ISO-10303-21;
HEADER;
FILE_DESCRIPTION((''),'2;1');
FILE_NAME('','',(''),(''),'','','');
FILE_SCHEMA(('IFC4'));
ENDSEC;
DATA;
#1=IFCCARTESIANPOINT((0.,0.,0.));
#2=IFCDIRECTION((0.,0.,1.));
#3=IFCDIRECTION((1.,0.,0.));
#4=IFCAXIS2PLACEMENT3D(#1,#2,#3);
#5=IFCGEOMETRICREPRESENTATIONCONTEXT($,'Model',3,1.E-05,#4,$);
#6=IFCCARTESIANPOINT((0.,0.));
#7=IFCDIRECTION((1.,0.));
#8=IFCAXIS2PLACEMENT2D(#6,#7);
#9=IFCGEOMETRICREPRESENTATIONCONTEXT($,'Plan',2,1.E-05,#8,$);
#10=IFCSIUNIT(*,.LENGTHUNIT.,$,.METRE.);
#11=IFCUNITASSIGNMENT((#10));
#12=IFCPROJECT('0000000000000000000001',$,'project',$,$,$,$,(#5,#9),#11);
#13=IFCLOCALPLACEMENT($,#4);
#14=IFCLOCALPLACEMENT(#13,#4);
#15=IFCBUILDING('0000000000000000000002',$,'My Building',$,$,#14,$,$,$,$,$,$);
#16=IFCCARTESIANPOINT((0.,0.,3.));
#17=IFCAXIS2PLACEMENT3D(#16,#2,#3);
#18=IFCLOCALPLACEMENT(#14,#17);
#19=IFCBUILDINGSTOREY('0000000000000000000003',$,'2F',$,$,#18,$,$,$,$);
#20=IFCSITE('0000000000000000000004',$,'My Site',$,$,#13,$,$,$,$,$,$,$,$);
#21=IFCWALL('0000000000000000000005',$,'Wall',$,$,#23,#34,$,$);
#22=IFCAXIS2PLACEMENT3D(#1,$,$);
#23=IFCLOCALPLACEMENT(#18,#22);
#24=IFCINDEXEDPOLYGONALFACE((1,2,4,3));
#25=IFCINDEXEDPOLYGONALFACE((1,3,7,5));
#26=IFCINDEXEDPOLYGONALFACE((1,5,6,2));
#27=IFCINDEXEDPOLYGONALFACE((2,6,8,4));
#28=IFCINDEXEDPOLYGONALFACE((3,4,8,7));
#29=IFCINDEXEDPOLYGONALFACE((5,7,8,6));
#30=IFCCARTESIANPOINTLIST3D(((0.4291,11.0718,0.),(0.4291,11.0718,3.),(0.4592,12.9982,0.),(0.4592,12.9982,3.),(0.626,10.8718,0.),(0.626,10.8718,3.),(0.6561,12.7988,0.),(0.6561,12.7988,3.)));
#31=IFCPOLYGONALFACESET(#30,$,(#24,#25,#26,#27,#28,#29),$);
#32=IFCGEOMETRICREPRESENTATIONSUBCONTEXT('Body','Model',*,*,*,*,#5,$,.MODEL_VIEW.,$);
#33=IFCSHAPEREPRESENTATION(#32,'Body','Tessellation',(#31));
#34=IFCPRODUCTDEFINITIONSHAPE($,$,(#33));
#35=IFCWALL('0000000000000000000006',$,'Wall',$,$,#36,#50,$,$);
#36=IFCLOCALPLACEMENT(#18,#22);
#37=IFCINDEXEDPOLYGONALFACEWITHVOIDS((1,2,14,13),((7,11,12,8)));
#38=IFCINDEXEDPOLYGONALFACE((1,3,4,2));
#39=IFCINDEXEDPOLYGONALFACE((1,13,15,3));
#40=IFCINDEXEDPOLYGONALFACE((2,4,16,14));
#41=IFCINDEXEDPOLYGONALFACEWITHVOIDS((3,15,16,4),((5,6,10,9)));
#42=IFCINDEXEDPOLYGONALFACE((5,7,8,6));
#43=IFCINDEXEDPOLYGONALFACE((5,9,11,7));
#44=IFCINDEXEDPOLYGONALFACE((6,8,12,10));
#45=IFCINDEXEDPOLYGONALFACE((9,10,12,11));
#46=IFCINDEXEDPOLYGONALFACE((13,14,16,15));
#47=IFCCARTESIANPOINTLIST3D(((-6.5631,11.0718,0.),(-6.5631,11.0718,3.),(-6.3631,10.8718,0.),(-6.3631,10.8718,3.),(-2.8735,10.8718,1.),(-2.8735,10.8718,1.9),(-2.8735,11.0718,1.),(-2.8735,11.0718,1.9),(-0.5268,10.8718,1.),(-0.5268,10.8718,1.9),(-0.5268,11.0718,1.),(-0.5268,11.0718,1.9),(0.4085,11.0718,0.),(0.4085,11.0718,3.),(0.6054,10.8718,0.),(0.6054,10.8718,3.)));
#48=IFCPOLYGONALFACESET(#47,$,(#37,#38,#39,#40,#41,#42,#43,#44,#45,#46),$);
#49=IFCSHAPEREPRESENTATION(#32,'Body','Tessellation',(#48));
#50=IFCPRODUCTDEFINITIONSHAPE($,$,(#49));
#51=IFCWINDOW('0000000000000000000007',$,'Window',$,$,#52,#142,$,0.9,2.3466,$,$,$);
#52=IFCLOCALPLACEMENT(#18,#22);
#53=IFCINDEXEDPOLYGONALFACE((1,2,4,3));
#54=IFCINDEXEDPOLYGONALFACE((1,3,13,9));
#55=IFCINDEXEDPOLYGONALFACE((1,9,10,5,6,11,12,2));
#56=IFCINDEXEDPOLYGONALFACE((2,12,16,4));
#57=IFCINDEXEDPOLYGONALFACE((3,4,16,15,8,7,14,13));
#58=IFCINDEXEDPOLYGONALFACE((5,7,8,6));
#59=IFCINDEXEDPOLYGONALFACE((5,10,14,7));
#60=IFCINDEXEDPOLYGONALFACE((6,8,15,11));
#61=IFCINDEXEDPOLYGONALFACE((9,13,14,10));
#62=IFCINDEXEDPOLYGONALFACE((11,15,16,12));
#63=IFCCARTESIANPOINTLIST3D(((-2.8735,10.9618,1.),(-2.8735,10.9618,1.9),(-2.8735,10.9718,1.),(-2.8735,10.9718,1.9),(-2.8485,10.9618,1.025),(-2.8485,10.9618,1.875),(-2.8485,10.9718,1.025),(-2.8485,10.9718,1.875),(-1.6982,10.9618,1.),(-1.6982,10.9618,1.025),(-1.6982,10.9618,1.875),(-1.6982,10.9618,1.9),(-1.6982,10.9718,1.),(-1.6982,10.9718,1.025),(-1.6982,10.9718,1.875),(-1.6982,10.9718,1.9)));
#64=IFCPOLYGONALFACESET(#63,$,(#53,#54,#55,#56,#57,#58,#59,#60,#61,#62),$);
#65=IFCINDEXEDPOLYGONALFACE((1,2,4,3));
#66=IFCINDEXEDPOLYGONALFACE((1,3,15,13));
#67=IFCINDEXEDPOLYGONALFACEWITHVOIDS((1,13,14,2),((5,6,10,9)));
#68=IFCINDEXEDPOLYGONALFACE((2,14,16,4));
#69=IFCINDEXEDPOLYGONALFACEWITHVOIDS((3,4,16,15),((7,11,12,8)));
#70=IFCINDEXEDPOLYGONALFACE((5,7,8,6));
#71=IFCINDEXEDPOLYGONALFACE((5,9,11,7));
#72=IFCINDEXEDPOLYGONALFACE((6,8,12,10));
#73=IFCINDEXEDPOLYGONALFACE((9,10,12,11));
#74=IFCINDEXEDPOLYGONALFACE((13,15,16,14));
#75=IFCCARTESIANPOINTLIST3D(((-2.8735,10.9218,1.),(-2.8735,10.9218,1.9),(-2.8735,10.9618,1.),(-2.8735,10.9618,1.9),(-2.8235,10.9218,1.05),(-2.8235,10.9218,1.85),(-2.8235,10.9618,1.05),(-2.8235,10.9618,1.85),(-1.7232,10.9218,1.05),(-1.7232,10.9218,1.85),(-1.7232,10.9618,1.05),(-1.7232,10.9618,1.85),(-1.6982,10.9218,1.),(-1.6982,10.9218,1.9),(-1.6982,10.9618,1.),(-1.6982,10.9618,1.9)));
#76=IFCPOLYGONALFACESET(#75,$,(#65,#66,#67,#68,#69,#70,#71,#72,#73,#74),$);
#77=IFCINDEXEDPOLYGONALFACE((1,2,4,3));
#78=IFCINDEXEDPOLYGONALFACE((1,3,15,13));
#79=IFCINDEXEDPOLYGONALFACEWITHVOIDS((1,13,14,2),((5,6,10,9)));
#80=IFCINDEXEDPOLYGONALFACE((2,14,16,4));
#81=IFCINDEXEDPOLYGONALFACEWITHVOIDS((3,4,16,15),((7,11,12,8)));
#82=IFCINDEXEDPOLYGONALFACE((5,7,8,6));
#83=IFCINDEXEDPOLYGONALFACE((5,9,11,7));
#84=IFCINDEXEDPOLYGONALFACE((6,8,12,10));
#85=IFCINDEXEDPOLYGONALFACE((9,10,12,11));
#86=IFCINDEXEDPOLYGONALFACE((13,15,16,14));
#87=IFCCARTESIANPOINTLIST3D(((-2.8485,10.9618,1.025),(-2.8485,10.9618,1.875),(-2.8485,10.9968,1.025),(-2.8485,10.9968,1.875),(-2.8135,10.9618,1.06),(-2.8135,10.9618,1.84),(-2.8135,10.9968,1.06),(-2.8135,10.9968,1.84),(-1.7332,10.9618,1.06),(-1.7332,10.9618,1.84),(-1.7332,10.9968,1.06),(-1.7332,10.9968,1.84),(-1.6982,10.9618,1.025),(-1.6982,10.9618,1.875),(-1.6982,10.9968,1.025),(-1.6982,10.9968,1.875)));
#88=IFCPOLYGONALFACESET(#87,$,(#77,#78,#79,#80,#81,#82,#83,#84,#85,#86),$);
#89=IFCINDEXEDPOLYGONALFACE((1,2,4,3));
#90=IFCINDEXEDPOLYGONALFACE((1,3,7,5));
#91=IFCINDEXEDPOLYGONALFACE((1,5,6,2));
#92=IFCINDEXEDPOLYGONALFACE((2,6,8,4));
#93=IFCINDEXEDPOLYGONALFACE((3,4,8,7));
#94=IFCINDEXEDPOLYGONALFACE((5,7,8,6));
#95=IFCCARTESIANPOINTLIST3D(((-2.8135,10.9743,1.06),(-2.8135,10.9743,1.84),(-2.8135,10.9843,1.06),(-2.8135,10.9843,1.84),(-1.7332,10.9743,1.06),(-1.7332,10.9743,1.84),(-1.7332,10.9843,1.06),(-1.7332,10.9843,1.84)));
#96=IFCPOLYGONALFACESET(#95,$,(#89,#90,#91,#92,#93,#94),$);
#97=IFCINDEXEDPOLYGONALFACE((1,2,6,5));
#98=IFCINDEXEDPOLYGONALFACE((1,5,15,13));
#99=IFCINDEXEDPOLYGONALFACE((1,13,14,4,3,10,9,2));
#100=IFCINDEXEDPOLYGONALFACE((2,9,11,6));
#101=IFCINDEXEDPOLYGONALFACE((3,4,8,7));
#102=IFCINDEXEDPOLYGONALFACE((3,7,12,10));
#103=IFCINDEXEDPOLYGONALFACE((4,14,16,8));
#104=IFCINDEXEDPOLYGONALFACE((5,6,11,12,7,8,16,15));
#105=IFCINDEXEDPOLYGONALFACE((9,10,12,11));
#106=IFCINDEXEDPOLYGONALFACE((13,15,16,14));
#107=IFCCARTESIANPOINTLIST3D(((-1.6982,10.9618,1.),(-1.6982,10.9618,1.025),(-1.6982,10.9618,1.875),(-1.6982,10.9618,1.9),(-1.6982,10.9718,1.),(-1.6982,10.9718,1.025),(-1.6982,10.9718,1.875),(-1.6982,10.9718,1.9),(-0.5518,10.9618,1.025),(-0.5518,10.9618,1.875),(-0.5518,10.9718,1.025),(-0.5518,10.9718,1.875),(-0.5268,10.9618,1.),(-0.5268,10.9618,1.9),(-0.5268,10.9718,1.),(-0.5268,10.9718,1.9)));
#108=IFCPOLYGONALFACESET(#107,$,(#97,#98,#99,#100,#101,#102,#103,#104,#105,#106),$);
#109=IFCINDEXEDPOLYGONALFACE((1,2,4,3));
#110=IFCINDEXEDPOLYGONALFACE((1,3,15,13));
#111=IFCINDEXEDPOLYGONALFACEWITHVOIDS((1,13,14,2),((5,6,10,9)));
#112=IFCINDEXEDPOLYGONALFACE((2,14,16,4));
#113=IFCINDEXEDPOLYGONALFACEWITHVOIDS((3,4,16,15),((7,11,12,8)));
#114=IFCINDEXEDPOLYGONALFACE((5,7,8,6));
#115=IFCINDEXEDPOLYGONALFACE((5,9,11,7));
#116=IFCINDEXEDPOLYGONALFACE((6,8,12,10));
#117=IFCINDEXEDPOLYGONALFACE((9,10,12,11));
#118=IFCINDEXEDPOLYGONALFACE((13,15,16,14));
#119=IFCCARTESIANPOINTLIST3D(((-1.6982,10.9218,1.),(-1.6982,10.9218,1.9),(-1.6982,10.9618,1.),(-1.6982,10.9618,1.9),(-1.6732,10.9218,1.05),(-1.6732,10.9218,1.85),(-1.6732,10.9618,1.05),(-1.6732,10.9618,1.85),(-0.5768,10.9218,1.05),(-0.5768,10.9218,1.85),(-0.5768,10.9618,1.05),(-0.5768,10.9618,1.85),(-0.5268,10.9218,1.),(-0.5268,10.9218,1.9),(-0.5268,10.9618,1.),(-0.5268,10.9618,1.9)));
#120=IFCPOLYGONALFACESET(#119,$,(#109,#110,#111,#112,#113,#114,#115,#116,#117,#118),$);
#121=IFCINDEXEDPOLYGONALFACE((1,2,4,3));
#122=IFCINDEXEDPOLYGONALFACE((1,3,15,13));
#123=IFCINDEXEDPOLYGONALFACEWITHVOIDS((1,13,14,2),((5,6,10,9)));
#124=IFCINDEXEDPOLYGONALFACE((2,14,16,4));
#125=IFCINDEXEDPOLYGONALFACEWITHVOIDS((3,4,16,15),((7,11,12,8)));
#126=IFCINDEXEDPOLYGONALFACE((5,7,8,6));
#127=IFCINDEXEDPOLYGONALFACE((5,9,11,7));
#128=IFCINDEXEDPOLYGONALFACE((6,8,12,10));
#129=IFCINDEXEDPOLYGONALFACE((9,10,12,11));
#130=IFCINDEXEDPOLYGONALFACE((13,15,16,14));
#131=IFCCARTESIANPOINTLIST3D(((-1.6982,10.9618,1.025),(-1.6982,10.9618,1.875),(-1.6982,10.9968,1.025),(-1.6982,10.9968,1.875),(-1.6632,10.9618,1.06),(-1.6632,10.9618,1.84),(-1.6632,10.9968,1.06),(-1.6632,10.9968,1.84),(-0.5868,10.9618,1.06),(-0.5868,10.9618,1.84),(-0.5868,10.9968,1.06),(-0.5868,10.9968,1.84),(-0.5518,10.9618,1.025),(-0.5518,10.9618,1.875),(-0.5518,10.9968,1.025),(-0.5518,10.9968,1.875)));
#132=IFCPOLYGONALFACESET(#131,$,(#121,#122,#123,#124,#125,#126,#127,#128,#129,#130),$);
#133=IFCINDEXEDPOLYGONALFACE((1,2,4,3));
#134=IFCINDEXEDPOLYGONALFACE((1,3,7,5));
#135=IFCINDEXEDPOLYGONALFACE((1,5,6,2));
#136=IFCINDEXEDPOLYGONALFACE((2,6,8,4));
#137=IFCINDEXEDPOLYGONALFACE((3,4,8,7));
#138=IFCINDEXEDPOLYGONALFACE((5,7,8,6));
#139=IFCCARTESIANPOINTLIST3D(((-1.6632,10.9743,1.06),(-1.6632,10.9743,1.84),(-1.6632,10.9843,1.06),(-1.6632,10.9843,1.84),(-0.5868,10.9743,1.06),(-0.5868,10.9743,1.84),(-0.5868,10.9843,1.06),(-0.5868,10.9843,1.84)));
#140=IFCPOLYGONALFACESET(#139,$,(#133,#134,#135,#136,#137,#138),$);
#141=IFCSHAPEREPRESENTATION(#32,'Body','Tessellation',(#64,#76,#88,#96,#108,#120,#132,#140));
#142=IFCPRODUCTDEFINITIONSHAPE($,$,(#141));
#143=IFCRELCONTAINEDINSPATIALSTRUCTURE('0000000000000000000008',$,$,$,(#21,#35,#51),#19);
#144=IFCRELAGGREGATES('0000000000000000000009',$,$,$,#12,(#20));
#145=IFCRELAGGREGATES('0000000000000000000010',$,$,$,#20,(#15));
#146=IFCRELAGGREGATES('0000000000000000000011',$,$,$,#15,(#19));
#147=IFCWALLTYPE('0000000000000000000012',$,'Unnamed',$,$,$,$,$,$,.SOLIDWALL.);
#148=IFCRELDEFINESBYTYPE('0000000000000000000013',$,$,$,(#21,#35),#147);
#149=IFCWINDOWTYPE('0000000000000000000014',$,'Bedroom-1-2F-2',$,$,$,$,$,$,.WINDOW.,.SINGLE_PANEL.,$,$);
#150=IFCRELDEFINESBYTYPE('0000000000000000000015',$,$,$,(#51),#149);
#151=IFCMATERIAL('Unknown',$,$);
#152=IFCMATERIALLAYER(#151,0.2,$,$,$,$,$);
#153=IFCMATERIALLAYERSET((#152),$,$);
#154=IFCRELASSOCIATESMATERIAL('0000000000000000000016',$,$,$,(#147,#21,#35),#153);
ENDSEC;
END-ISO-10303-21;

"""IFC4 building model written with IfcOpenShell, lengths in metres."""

from ifc_helpers import new_model, entity, si_unit, frame, origin_with_axes, origin_2d_with_axis, place, context, subcontext, project, spatial, line, indexed_curve, outline, extrude, shape, source, transform, mapped, material, layer, layer_set, layer_usage, type_object, type_shapes, element, fill, save


model = new_model("IFC4")

# Units and contexts
model_context = context("Model", 3, precision=1e-05, world=origin_with_axes())
plan_context = context("Plan", 2, precision=1e-05, world=origin_2d_with_axis())
body_context_1 = subcontext(model_context, "Body", "Model", "MODEL_VIEW")
body_context_2 = subcontext(plan_context, "Body", "Plan", "PLAN_VIEW")
ifc_project = project(units=[si_unit("LENGTHUNIT", "METRE")], contexts=[model_context, plan_context])

# Site, building, storey
site_placement = place(None, origin_with_axes())
site = spatial("IfcSite", under=ifc_project, at=site_placement, Name="My Site")
building_placement = place(site_placement, origin_with_axes())
building = spatial("IfcBuilding", under=site, at=building_placement, Name="My Building")
storey_placement = place(building_placement, frame((0.0, 0.0, 3.0), z_axis=(0.0, 0.0, 1.0), x_axis=(1.0, 0.0, 0.0)))
storey = spatial("IfcBuildingStorey", under=building, at=storey_placement, Name="2F")

# Shared definitions
ifc_material = material(Name="Unknown")

# Shared definitions
ifc_layer_1 = layer(ifc_material, 0.2)
ifc_layer_set_1 = layer_set([ifc_layer_1])
wall_type = type_object("IfcWallType", Name="Unnamed", PredefinedType="SOLIDWALL", material=ifc_layer_set_1)

# Wall
ifc_layer_usage_1 = layer_usage(ifc_layer_set_1, "AXIS2", "POSITIVE", 0.0)
wall_1_placement = place(storey_placement, frame((0.4592, 12.9982, 0.0), z_axis=(0.0, 0.0, 1.0), x_axis=(-0.015623, -0.999878, 0.0)))
element("IfcWall", 1, at=wall_1_placement, inside=storey, type_object=wall_type, material=ifc_layer_usage_1, Name="Wall", context=body_context_1, shape_type="SweptSolid", body=[
    extrude(outline(indexed_curve([(0.0, 0.0), (0.1962, 0.2), (2.1235, 0.2), (1.9266, 0.0)], segments=[line(1, 2, 3, 4, 1)])), origin_with_axes(), (0.0, 0.0, 1.0), 3.0),
])

# Wall, opening, window
ifc_layer_usage_2 = layer_usage(ifc_layer_set_1, "AXIS2", "POSITIVE", 0.0)
wall_2_placement = place(storey_placement, frame((0.4085, 11.0718, 0.0), z_axis=(0.0, 0.0, 1.0), x_axis=(-1.0, 0.0, 0.0)))
wall_2 = element("IfcWall", 2, at=wall_2_placement, inside=storey, type_object=wall_type, material=ifc_layer_usage_2, Name="Wall", context=body_context_1, shape_type="SweptSolid", body=[
    extrude(outline(indexed_curve([(0.0, 0.0), (-0.1969, 0.2), (6.7716, 0.2), (6.9715, 0.0)], segments=[line(1, 2, 3, 4, 1)])), origin_with_axes(), (0.0, 0.0, 1.0), 3.0),
])
shared_shape_1 = source(origin_with_axes(), body_context_1, "Body", "SweptSolid", [
    extrude(outline(indexed_curve([(0.0, 0.0), (2.3466, 0.0), (2.3466, 0.9), (0.0, 0.9)], segments=[line(1, 2, 3, 4, 1)])), frame((0.0, -0.6, 0.0), z_axis=(0.0, -1.0, 0.0), x_axis=(1.0, 0.0, 0.0)), (0.0, 0.0, -1.0), 1.2),
])
opening_1_placement = place(wall_2_placement, frame((3.2819, 0.2, 1.0), z_axis=(0.0, 0.0, 1.0), x_axis=(-1.0, 0.0, 0.0)))
opening_1 = element("IfcOpeningElement", 3, at=opening_1_placement, cuts=wall_2, PredefinedType="OPENING", context=body_context_1, shape_type="MappedRepresentation", body=[
    mapped(shared_shape_1, transform((0.0, 0.0, 0.0), x_axis=(1.0, 0.0, 0.0), y_axis=(0.0, 1.0, 0.0), z_axis=(0.0, 0.0, 1.0), scale=1.0)),
])
window_type_1 = type_object("IfcWindowType", Name="Bedroom-1-2F-2", PartitioningType="SINGLE_PANEL", PredefinedType="WINDOW")
shared_shape_2 = source(origin_with_axes(), body_context_1, "Body", "SweptSolid", [
    extrude(outline(indexed_curve([(1.1752, 0.0), (0.0, 0.0), (0.0, 0.9), (1.1752, 0.9), (1.1752, 0.875), (0.025, 0.875), (0.025, 0.025), (1.1752, 0.025)], segments=[line(1, 2, 3, 4, 5, 6, 7, 8, 1)])), frame((0.0, 0.09, 0.0), z_axis=(0.0, -1.0, 0.0), x_axis=(1.0, 0.0, 0.0)), (0.0, 0.0, -1.0), 0.01),
    extrude(outline(indexed_curve([(0.0, 0.0), (1.1752, 0.0), (1.1752, 0.9), (0.0, 0.9)], segments=[line(1, 2, 3, 4, 1)]), holes=[indexed_curve([(0.05, 0.05), (1.1502, 0.05), (1.1502, 0.85), (0.05, 0.85)], segments=[line(1, 2, 3, 4, 1)])]), frame((0.0, 0.05, 0.0), z_axis=(0.0, -1.0, 0.0), x_axis=(1.0, 0.0, 0.0)), (0.0, 0.0, -1.0), 0.04),
    extrude(outline(indexed_curve([(0.0, 0.0), (1.1502, 0.0), (1.1502, 0.85), (0.0, 0.85)], segments=[line(1, 2, 3, 4, 1)]), holes=[indexed_curve([(0.035, 0.035), (1.1152, 0.035), (1.1152, 0.815), (0.035, 0.815)], segments=[line(1, 2, 3, 4, 1)])]), frame((0.025, 0.09, 0.025), z_axis=(0.0, -1.0, 0.0), x_axis=(1.0, 0.0, 0.0)), (0.0, 0.0, -1.0), 0.035),
    extrude(outline(indexed_curve([(0.035, 0.035), (1.1152, 0.035), (1.1152, 0.815), (0.035, 0.815)], segments=[line(1, 2, 3, 4, 1)])), frame((0.025, 0.1025, 0.025), z_axis=(0.0, -1.0, 0.0), x_axis=(1.0, 0.0, 0.0)), (0.0, 0.0, -1.0), 0.01),
    extrude(outline(indexed_curve([(0.0, 0.9), (1.1714, 0.9), (1.1714, 0.0), (0.0, 0.0), (0.0, 0.025), (1.1464, 0.025), (1.1464, 0.875), (0.0, 0.875)], segments=[line(1, 2, 3, 4, 5, 6, 7, 8, 1)])), frame((1.1752, 0.09, 0.0), z_axis=(0.0, -1.0, 0.0), x_axis=(1.0, 0.0, 0.0)), (0.0, 0.0, -1.0), 0.01),
    extrude(outline(indexed_curve([(0.0, 0.0), (1.1714, 0.0), (1.1714, 0.9), (0.0, 0.9)], segments=[line(1, 2, 3, 4, 1)]), holes=[indexed_curve([(0.025, 0.05), (1.1214, 0.05), (1.1214, 0.85), (0.025, 0.85)], segments=[line(1, 2, 3, 4, 1)])]), frame((1.1752, 0.05, 0.0), z_axis=(0.0, -1.0, 0.0), x_axis=(1.0, 0.0, 0.0)), (0.0, 0.0, -1.0), 0.04),
    extrude(outline(indexed_curve([(0.0, 0.0), (1.1464, 0.0), (1.1464, 0.85), (0.0, 0.85)], segments=[line(1, 2, 3, 4, 1)]), holes=[indexed_curve([(0.035, 0.035), (1.1114, 0.035), (1.1114, 0.815), (0.035, 0.815)], segments=[line(1, 2, 3, 4, 1)])]), frame((1.1752, 0.09, 0.025), z_axis=(0.0, -1.0, 0.0), x_axis=(1.0, 0.0, 0.0)), (0.0, 0.0, -1.0), 0.035),
    extrude(outline(indexed_curve([(0.035, 0.035), (1.1114, 0.035), (1.1114, 0.815), (0.035, 0.815)], segments=[line(1, 2, 3, 4, 1)])), frame((1.1752, 0.1025, 0.025), z_axis=(0.0, -1.0, 0.0), x_axis=(1.0, 0.0, 0.0)), (0.0, 0.0, -1.0), 0.01),
])
shared_shape_3 = source(origin_with_axes(), body_context_2, "Body", "Curve2D", [
    entity("IfcIndexedPolyCurve", entity("IfcCartesianPointList2D", [[0.05, 0.05], [1.1502, 0.05]])),
    entity("IfcIndexedPolyCurve", entity("IfcCartesianPointList2D", [[0.0, 0.1], [0.025, 0.1], [0.025, 0.09], [0.05, 0.09], [0.05, 0.05], [0.0, 0.05]]), [entity("IfcLineIndex", [1, 2, 3, 4, 5, 6, 1])]),
    entity("IfcIndexedPolyCurve", entity("IfcCartesianPointList2D", [[1.1752, 0.1], [1.1752, 0.1], [1.1752, 0.09], [1.1502, 0.09], [1.1502, 0.05], [1.1752, 0.05]])),
    entity("IfcIndexedPolyCurve", entity("IfcCartesianPointList2D", [[0.025, 0.09], [0.06, 0.09], [0.06, 0.125], [0.025, 0.125]]), [entity("IfcLineIndex", [1, 2, 3, 4, 1])]),
    entity("IfcIndexedPolyCurve", entity("IfcCartesianPointList2D", [[1.1752, 0.09], [1.1402, 0.09], [1.1402, 0.125], [1.1752, 0.125]]), [entity("IfcLineIndex", [1, 2, 3, 4, 1])]),
    entity("IfcIndexedPolyCurve", entity("IfcCartesianPointList2D", [[0.06, 0.09], [1.1402, 0.09]])),
    entity("IfcIndexedPolyCurve", entity("IfcCartesianPointList2D", [[0.06, 0.125], [1.1402, 0.125]])),
    entity("IfcIndexedPolyCurve", entity("IfcCartesianPointList2D", [[0.06, 0.1075], [1.1402, 0.1075]])),
    entity("IfcIndexedPolyCurve", entity("IfcCartesianPointList2D", [[1.2002, 0.05], [2.2966, 0.05]])),
    entity("IfcIndexedPolyCurve", entity("IfcCartesianPointList2D", [[1.1752, 0.1], [1.1752, 0.1], [1.1752, 0.09], [1.2002, 0.09], [1.2002, 0.05], [1.1752, 0.05]])),
    entity("IfcIndexedPolyCurve", entity("IfcCartesianPointList2D", [[2.3466, 0.1], [2.3216, 0.1], [2.3216, 0.09], [2.2966, 0.09], [2.2966, 0.05], [2.3466, 0.05]]), [entity("IfcLineIndex", [1, 2, 3, 4, 5, 6, 1])]),
    entity("IfcIndexedPolyCurve", entity("IfcCartesianPointList2D", [[1.1752, 0.09], [1.2102, 0.09], [1.2102, 0.125], [1.1752, 0.125]]), [entity("IfcLineIndex", [1, 2, 3, 4, 1])]),
    entity("IfcIndexedPolyCurve", entity("IfcCartesianPointList2D", [[2.3216, 0.09], [2.2866, 0.09], [2.2866, 0.125], [2.3216, 0.125]]), [entity("IfcLineIndex", [1, 2, 3, 4, 1])]),
    entity("IfcIndexedPolyCurve", entity("IfcCartesianPointList2D", [[1.2102, 0.09], [2.2866, 0.09]])),
    entity("IfcIndexedPolyCurve", entity("IfcCartesianPointList2D", [[1.2102, 0.125], [2.2866, 0.125]])),
    entity("IfcIndexedPolyCurve", entity("IfcCartesianPointList2D", [[1.2102, 0.1075], [2.2866, 0.1075]])),
])
type_shapes(window_type_1, [shared_shape_2, shared_shape_3])
window_1_placement = place(opening_1_placement, frame((0.0, 0.0, 0.0), z_axis=(0.0, 0.0, 1.0), x_axis=(1.0, 0.0, 0.0)))
window_1 = element("IfcWindow", 4, at=window_1_placement, inside=storey, type_object=window_type_1, Name="Window", OverallHeight=0.9, OverallWidth=2.3466, shapes=[
    shape(body_context_1, "Body", "MappedRepresentation", [mapped(shared_shape_2, transform((0.0, 0.0, 0.0), x_axis=(1.0, 0.0, 0.0), y_axis=(0.0, 1.0, 0.0), z_axis=(0.0, 0.0, 1.0), scale=1.0))]),
    shape(body_context_2, "Body", "MappedRepresentation", [mapped(shared_shape_3, transform((0.0, 0.0, 0.0), x_axis=(1.0, 0.0, 0.0), y_axis=(0.0, 1.0, 0.0), z_axis=(0.0, 0.0, 1.0), scale=1.0))]),
])
fill(opening_1, window_1)

save(model, "model.ifc")
